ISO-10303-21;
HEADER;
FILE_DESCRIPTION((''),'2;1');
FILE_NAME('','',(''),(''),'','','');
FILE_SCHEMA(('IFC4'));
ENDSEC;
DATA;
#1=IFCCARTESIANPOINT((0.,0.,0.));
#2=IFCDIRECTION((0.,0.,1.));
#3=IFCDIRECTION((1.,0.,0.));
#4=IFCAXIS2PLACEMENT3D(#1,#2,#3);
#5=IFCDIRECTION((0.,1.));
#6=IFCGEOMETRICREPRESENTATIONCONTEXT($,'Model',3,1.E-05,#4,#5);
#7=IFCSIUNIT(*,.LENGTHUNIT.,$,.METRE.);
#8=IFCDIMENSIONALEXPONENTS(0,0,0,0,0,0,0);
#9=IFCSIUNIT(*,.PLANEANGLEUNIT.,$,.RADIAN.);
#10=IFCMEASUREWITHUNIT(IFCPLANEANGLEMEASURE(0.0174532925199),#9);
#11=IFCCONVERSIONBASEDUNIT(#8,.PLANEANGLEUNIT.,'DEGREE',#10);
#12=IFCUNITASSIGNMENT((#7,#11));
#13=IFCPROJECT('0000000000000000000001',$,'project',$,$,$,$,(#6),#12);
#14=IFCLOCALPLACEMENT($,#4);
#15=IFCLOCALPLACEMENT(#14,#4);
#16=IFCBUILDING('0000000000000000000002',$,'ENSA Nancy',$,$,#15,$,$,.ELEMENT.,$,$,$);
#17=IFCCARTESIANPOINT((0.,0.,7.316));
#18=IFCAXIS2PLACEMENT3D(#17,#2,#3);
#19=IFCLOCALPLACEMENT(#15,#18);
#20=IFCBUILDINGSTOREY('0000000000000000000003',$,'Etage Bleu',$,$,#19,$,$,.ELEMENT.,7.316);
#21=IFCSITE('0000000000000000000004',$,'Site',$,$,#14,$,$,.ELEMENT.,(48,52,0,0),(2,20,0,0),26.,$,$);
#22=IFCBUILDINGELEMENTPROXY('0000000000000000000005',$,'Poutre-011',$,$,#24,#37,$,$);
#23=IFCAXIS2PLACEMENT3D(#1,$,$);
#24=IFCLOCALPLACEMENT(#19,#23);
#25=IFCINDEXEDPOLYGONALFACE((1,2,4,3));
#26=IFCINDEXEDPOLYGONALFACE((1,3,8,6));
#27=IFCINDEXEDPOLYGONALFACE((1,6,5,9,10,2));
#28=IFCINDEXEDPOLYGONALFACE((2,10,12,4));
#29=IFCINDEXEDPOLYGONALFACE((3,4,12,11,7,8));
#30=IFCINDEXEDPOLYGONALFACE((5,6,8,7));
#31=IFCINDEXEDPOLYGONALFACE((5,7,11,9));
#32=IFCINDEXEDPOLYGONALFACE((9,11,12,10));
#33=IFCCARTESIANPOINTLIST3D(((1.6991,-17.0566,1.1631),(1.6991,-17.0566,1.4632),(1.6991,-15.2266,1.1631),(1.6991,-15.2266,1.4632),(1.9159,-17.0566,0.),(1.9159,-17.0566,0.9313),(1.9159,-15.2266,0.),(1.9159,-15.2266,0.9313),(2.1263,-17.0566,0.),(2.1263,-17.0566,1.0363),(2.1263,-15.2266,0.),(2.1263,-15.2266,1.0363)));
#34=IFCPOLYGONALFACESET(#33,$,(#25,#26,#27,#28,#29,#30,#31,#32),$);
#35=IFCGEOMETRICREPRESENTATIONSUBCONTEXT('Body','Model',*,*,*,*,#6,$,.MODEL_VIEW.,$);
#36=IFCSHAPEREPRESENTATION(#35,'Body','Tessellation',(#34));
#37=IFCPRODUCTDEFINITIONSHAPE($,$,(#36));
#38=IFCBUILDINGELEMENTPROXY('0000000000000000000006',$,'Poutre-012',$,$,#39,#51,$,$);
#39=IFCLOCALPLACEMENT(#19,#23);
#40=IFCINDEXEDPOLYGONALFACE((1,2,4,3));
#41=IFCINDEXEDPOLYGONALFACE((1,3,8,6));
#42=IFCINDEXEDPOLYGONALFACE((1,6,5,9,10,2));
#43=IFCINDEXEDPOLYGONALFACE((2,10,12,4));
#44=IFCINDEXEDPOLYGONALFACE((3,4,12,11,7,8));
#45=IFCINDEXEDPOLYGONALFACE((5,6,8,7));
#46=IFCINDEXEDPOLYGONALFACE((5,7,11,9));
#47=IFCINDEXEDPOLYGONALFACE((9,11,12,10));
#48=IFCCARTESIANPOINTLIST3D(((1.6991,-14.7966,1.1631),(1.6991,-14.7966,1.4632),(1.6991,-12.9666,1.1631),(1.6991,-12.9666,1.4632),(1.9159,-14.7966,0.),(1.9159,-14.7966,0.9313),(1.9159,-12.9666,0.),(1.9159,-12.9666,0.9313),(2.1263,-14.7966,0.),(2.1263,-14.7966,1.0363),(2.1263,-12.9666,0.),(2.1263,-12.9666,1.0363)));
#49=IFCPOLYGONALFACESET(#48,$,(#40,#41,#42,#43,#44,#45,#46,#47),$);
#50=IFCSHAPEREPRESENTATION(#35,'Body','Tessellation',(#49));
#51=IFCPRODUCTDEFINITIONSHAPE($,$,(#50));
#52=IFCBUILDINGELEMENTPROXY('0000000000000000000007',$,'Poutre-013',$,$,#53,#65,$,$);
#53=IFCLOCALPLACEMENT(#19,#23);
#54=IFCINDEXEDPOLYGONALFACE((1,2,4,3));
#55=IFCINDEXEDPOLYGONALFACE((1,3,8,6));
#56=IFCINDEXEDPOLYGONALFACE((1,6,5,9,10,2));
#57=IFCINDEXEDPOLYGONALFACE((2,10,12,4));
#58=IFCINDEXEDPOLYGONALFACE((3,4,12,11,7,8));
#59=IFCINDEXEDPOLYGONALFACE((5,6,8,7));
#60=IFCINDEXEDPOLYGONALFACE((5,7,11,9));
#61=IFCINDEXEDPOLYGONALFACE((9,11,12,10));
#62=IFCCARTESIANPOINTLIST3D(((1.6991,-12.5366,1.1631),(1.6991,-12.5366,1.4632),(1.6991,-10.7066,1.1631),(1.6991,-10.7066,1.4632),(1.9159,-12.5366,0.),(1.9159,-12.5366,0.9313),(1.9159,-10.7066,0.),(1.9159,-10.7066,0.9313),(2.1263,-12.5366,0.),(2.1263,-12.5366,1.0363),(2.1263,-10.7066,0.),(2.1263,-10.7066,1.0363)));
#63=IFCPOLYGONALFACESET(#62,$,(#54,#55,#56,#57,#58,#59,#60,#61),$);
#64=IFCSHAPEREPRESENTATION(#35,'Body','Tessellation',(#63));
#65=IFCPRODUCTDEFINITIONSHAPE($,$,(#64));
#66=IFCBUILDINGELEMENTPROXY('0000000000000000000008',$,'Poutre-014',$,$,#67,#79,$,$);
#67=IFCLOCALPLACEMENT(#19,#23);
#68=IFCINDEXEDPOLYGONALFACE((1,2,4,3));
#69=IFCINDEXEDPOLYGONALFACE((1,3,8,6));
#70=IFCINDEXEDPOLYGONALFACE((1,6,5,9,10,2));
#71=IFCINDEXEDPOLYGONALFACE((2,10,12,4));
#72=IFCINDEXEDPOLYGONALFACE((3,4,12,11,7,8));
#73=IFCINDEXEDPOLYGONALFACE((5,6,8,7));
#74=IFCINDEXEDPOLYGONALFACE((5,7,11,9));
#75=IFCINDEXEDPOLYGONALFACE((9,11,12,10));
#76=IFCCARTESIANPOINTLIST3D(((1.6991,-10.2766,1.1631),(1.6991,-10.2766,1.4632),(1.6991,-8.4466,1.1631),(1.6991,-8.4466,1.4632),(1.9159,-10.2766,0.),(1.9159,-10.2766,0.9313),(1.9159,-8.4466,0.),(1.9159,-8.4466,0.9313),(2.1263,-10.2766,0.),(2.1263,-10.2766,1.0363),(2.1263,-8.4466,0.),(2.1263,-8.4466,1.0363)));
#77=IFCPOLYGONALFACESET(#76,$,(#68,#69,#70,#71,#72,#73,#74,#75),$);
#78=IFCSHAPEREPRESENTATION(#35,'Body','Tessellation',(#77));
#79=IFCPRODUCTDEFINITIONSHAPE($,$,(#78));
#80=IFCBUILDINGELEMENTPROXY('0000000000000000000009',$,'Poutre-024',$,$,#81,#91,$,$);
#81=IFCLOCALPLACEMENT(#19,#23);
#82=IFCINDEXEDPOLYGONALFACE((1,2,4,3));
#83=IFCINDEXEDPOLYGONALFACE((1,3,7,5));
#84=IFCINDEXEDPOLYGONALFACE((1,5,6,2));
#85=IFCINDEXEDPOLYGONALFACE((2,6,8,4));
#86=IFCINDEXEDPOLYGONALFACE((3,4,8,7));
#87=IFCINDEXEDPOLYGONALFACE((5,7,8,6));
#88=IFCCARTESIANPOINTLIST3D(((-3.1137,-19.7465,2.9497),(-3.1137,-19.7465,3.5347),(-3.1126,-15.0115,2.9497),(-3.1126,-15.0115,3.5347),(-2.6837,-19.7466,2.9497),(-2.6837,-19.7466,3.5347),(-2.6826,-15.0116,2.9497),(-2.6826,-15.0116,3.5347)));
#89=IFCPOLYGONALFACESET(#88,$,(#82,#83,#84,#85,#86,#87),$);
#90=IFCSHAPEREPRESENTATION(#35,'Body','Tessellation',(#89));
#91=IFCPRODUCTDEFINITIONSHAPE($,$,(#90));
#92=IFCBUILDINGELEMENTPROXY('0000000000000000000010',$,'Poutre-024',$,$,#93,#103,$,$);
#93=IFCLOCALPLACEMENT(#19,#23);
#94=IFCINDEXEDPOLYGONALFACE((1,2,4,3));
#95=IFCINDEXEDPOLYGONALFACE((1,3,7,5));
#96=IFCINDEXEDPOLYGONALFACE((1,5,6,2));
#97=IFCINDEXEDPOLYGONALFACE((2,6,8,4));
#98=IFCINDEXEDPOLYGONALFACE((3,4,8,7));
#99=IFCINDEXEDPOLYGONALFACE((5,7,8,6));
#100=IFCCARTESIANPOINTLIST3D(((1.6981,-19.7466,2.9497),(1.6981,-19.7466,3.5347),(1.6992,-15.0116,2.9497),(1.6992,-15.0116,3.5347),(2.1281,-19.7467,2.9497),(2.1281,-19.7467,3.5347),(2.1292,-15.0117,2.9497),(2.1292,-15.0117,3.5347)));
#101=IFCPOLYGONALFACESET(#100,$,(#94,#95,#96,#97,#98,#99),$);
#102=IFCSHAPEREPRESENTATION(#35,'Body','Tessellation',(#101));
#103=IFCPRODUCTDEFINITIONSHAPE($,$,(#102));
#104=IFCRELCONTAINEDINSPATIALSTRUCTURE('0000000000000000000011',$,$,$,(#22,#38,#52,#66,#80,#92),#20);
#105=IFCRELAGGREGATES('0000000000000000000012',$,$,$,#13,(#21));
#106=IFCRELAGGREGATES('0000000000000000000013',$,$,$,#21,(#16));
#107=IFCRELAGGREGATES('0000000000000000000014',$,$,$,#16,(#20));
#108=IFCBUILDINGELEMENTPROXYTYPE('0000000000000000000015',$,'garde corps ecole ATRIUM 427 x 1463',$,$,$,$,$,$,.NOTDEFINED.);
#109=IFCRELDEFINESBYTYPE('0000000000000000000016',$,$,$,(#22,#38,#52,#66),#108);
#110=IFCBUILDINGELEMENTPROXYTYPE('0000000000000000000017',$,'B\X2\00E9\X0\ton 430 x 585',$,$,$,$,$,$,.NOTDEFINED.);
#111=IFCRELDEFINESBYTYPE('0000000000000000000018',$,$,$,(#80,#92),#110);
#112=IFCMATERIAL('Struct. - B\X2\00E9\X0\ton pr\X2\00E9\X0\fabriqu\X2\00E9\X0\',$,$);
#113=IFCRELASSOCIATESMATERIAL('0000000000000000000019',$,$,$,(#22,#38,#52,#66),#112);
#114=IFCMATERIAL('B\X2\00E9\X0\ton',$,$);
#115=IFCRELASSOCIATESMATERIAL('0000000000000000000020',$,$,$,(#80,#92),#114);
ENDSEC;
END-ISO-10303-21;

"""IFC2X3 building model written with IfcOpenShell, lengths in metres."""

from ifc_helpers import new_model, entity, si_unit, converted_unit, direction, frame, frame_2d, origin_with_axes, place, context, subcontext, project, spatial, polyline, rectangle, outline, extrude, material, type_object, element, save


model = new_model("IFC2X3")

# Units and contexts
model_context = context("Model", 3, precision=1e-05, world=origin_with_axes(), true_north=direction((0.0, 1.0)))
body_context = subcontext(model_context, "Body", "Model", "MODEL_VIEW")
ifc_project = project(units=[si_unit("LENGTHUNIT", "METRE"), converted_unit("PLANEANGLEUNIT", "DEGREE", entity("IfcPlaneAngleMeasure", 0.0174532925199), si_unit("PLANEANGLEUNIT", "RADIAN"), dimensions=[0, 0, 0, 0, 0, 0, 0])], contexts=[model_context])

# Site, building, storey
site_placement = place(None, origin_with_axes())
site = spatial("IfcSite", under=ifc_project, at=site_placement, Name="Site", CompositionType="ELEMENT", RefLatitude=(48, 52, 0, 0), RefLongitude=(2, 20, 0, 0), RefElevation=26.0)
building_placement = place(site_placement, origin_with_axes())
building = spatial("IfcBuilding", under=site, at=building_placement, Name="ENSA Nancy", CompositionType="ELEMENT")
storey_placement = place(building_placement, frame((0.0, 0.0, 7.316), z_axis=(0.0, 0.0, 1.0), x_axis=(1.0, 0.0, 0.0)))
storey = spatial("IfcBuildingStorey", under=building, at=storey_placement, Name="Etage Bleu", CompositionType="ELEMENT", Elevation=7.316)

# Building element proxies
ifc_material_1 = material(Name="Béton")
ifc_material_2 = material(Name="Struct. - Béton préfabriqué")
building_element_proxy_type_1 = type_object("IfcBuildingElementProxyType", Name="garde corps ecole ATRIUM 427 x 1463", PredefinedType="NOTDEFINED")
proxy_1_placement = place(storey_placement, frame((2.1263, -17.0566, 0.0), z_axis=(0.0, 0.0, 1.0), x_axis=(1.0, 0.0, 0.0)))
element("IfcBuildingElementProxy", 1, at=proxy_1_placement, inside=storey, type_object=building_element_proxy_type_1, material=ifc_material_2, Name="Poutre-011", context=body_context, shape_type="SweptSolid", body=[
    extrude(outline(polyline([(0.0, 1.0363), (0.0, 0.0), (0.2105, 0.0), (0.2105, 0.9313), (0.4272, 1.1631), (0.4272, 1.4632), (0.0, 1.0363)])), frame((0.0, 1.83, 0.0), z_axis=(0.0, 1.0, 0.0), x_axis=(-1.0, 0.0, 0.0)), (0.0, 0.0, -1.0), 1.83),
])
proxy_2_placement = place(storey_placement, frame((2.1263, -14.7966, 0.0), z_axis=(0.0, 0.0, 1.0), x_axis=(1.0, 0.0, 0.0)))
element("IfcBuildingElementProxy", 2, at=proxy_2_placement, inside=storey, type_object=building_element_proxy_type_1, material=ifc_material_2, Name="Poutre-012", context=body_context, shape_type="SweptSolid", body=[
    extrude(outline(polyline([(0.0, 1.0363), (0.0, 0.0), (0.2105, 0.0), (0.2105, 0.9313), (0.4272, 1.1631), (0.4272, 1.4632), (0.0, 1.0363)])), frame((0.0, 1.83, 0.0), z_axis=(0.0, 1.0, 0.0), x_axis=(-1.0, 0.0, 0.0)), (0.0, 0.0, -1.0), 1.83),
])
proxy_3_placement = place(storey_placement, frame((2.1263, -12.5366, 0.0), z_axis=(0.0, 0.0, 1.0), x_axis=(1.0, 0.0, 0.0)))
element("IfcBuildingElementProxy", 3, at=proxy_3_placement, inside=storey, type_object=building_element_proxy_type_1, material=ifc_material_2, Name="Poutre-013", context=body_context, shape_type="SweptSolid", body=[
    extrude(outline(polyline([(0.0, 1.0363), (0.0, 0.0), (0.2105, 0.0), (0.2105, 0.9313), (0.4272, 1.1631), (0.4272, 1.4632), (0.0, 1.0363)])), frame((0.0, 1.83, 0.0), z_axis=(0.0, 1.0, 0.0), x_axis=(-1.0, 0.0, 0.0)), (0.0, 0.0, -1.0), 1.83),
])
proxy_4_placement = place(storey_placement, frame((2.1263, -10.2766, 0.0), z_axis=(0.0, 0.0, 1.0), x_axis=(1.0, 0.0, 0.0)))
element("IfcBuildingElementProxy", 4, at=proxy_4_placement, inside=storey, type_object=building_element_proxy_type_1, material=ifc_material_2, Name="Poutre-014", context=body_context, shape_type="SweptSolid", body=[
    extrude(outline(polyline([(0.0, 1.0363), (0.0, 0.0), (0.2105, 0.0), (0.2105, 0.9313), (0.4272, 1.1631), (0.4272, 1.4632), (0.0, 1.0363)])), frame((0.0, 1.83, 0.0), z_axis=(0.0, 1.0, 0.0), x_axis=(-1.0, 0.0, 0.0)), (0.0, 0.0, -1.0), 1.83),
])
building_element_proxy_type_2 = type_object("IfcBuildingElementProxyType", Name="Béton 430 x 585", PredefinedType="NOTDEFINED")
for number, where, z_axis, x_axis, name in (
    (5, (-2.8987, -19.7466, 3.5347), (0.0, 0.0, 1.0), (1.0, -0.000247, 0.0), "Poutre-024"),
    (6, (1.9131, -19.7466, 3.5347), (0.0, 0.0, 1.0), (1.0, -0.000247, 0.0), "Poutre-024"),
):
    element("IfcBuildingElementProxy", number, at=place(storey_placement, frame(where, z_axis=z_axis, x_axis=x_axis)), inside=storey, type_object=building_element_proxy_type_2, material=ifc_material_1, Name=name, context=body_context, shape_type="SweptSolid", body=[
        extrude(rectangle(XDim=0.585, YDim=0.43, at=frame_2d((-0.2925, 0.0), x_axis=(1.0, 0.0))), frame((0.0, 0.0, 0.0), z_axis=(0.0, 1.0, 0.0), x_axis=(0.0, 0.0, 1.0)), (0.0, 0.0, 1.0), 4.735),
    ])

save(model, "model.ifc")
